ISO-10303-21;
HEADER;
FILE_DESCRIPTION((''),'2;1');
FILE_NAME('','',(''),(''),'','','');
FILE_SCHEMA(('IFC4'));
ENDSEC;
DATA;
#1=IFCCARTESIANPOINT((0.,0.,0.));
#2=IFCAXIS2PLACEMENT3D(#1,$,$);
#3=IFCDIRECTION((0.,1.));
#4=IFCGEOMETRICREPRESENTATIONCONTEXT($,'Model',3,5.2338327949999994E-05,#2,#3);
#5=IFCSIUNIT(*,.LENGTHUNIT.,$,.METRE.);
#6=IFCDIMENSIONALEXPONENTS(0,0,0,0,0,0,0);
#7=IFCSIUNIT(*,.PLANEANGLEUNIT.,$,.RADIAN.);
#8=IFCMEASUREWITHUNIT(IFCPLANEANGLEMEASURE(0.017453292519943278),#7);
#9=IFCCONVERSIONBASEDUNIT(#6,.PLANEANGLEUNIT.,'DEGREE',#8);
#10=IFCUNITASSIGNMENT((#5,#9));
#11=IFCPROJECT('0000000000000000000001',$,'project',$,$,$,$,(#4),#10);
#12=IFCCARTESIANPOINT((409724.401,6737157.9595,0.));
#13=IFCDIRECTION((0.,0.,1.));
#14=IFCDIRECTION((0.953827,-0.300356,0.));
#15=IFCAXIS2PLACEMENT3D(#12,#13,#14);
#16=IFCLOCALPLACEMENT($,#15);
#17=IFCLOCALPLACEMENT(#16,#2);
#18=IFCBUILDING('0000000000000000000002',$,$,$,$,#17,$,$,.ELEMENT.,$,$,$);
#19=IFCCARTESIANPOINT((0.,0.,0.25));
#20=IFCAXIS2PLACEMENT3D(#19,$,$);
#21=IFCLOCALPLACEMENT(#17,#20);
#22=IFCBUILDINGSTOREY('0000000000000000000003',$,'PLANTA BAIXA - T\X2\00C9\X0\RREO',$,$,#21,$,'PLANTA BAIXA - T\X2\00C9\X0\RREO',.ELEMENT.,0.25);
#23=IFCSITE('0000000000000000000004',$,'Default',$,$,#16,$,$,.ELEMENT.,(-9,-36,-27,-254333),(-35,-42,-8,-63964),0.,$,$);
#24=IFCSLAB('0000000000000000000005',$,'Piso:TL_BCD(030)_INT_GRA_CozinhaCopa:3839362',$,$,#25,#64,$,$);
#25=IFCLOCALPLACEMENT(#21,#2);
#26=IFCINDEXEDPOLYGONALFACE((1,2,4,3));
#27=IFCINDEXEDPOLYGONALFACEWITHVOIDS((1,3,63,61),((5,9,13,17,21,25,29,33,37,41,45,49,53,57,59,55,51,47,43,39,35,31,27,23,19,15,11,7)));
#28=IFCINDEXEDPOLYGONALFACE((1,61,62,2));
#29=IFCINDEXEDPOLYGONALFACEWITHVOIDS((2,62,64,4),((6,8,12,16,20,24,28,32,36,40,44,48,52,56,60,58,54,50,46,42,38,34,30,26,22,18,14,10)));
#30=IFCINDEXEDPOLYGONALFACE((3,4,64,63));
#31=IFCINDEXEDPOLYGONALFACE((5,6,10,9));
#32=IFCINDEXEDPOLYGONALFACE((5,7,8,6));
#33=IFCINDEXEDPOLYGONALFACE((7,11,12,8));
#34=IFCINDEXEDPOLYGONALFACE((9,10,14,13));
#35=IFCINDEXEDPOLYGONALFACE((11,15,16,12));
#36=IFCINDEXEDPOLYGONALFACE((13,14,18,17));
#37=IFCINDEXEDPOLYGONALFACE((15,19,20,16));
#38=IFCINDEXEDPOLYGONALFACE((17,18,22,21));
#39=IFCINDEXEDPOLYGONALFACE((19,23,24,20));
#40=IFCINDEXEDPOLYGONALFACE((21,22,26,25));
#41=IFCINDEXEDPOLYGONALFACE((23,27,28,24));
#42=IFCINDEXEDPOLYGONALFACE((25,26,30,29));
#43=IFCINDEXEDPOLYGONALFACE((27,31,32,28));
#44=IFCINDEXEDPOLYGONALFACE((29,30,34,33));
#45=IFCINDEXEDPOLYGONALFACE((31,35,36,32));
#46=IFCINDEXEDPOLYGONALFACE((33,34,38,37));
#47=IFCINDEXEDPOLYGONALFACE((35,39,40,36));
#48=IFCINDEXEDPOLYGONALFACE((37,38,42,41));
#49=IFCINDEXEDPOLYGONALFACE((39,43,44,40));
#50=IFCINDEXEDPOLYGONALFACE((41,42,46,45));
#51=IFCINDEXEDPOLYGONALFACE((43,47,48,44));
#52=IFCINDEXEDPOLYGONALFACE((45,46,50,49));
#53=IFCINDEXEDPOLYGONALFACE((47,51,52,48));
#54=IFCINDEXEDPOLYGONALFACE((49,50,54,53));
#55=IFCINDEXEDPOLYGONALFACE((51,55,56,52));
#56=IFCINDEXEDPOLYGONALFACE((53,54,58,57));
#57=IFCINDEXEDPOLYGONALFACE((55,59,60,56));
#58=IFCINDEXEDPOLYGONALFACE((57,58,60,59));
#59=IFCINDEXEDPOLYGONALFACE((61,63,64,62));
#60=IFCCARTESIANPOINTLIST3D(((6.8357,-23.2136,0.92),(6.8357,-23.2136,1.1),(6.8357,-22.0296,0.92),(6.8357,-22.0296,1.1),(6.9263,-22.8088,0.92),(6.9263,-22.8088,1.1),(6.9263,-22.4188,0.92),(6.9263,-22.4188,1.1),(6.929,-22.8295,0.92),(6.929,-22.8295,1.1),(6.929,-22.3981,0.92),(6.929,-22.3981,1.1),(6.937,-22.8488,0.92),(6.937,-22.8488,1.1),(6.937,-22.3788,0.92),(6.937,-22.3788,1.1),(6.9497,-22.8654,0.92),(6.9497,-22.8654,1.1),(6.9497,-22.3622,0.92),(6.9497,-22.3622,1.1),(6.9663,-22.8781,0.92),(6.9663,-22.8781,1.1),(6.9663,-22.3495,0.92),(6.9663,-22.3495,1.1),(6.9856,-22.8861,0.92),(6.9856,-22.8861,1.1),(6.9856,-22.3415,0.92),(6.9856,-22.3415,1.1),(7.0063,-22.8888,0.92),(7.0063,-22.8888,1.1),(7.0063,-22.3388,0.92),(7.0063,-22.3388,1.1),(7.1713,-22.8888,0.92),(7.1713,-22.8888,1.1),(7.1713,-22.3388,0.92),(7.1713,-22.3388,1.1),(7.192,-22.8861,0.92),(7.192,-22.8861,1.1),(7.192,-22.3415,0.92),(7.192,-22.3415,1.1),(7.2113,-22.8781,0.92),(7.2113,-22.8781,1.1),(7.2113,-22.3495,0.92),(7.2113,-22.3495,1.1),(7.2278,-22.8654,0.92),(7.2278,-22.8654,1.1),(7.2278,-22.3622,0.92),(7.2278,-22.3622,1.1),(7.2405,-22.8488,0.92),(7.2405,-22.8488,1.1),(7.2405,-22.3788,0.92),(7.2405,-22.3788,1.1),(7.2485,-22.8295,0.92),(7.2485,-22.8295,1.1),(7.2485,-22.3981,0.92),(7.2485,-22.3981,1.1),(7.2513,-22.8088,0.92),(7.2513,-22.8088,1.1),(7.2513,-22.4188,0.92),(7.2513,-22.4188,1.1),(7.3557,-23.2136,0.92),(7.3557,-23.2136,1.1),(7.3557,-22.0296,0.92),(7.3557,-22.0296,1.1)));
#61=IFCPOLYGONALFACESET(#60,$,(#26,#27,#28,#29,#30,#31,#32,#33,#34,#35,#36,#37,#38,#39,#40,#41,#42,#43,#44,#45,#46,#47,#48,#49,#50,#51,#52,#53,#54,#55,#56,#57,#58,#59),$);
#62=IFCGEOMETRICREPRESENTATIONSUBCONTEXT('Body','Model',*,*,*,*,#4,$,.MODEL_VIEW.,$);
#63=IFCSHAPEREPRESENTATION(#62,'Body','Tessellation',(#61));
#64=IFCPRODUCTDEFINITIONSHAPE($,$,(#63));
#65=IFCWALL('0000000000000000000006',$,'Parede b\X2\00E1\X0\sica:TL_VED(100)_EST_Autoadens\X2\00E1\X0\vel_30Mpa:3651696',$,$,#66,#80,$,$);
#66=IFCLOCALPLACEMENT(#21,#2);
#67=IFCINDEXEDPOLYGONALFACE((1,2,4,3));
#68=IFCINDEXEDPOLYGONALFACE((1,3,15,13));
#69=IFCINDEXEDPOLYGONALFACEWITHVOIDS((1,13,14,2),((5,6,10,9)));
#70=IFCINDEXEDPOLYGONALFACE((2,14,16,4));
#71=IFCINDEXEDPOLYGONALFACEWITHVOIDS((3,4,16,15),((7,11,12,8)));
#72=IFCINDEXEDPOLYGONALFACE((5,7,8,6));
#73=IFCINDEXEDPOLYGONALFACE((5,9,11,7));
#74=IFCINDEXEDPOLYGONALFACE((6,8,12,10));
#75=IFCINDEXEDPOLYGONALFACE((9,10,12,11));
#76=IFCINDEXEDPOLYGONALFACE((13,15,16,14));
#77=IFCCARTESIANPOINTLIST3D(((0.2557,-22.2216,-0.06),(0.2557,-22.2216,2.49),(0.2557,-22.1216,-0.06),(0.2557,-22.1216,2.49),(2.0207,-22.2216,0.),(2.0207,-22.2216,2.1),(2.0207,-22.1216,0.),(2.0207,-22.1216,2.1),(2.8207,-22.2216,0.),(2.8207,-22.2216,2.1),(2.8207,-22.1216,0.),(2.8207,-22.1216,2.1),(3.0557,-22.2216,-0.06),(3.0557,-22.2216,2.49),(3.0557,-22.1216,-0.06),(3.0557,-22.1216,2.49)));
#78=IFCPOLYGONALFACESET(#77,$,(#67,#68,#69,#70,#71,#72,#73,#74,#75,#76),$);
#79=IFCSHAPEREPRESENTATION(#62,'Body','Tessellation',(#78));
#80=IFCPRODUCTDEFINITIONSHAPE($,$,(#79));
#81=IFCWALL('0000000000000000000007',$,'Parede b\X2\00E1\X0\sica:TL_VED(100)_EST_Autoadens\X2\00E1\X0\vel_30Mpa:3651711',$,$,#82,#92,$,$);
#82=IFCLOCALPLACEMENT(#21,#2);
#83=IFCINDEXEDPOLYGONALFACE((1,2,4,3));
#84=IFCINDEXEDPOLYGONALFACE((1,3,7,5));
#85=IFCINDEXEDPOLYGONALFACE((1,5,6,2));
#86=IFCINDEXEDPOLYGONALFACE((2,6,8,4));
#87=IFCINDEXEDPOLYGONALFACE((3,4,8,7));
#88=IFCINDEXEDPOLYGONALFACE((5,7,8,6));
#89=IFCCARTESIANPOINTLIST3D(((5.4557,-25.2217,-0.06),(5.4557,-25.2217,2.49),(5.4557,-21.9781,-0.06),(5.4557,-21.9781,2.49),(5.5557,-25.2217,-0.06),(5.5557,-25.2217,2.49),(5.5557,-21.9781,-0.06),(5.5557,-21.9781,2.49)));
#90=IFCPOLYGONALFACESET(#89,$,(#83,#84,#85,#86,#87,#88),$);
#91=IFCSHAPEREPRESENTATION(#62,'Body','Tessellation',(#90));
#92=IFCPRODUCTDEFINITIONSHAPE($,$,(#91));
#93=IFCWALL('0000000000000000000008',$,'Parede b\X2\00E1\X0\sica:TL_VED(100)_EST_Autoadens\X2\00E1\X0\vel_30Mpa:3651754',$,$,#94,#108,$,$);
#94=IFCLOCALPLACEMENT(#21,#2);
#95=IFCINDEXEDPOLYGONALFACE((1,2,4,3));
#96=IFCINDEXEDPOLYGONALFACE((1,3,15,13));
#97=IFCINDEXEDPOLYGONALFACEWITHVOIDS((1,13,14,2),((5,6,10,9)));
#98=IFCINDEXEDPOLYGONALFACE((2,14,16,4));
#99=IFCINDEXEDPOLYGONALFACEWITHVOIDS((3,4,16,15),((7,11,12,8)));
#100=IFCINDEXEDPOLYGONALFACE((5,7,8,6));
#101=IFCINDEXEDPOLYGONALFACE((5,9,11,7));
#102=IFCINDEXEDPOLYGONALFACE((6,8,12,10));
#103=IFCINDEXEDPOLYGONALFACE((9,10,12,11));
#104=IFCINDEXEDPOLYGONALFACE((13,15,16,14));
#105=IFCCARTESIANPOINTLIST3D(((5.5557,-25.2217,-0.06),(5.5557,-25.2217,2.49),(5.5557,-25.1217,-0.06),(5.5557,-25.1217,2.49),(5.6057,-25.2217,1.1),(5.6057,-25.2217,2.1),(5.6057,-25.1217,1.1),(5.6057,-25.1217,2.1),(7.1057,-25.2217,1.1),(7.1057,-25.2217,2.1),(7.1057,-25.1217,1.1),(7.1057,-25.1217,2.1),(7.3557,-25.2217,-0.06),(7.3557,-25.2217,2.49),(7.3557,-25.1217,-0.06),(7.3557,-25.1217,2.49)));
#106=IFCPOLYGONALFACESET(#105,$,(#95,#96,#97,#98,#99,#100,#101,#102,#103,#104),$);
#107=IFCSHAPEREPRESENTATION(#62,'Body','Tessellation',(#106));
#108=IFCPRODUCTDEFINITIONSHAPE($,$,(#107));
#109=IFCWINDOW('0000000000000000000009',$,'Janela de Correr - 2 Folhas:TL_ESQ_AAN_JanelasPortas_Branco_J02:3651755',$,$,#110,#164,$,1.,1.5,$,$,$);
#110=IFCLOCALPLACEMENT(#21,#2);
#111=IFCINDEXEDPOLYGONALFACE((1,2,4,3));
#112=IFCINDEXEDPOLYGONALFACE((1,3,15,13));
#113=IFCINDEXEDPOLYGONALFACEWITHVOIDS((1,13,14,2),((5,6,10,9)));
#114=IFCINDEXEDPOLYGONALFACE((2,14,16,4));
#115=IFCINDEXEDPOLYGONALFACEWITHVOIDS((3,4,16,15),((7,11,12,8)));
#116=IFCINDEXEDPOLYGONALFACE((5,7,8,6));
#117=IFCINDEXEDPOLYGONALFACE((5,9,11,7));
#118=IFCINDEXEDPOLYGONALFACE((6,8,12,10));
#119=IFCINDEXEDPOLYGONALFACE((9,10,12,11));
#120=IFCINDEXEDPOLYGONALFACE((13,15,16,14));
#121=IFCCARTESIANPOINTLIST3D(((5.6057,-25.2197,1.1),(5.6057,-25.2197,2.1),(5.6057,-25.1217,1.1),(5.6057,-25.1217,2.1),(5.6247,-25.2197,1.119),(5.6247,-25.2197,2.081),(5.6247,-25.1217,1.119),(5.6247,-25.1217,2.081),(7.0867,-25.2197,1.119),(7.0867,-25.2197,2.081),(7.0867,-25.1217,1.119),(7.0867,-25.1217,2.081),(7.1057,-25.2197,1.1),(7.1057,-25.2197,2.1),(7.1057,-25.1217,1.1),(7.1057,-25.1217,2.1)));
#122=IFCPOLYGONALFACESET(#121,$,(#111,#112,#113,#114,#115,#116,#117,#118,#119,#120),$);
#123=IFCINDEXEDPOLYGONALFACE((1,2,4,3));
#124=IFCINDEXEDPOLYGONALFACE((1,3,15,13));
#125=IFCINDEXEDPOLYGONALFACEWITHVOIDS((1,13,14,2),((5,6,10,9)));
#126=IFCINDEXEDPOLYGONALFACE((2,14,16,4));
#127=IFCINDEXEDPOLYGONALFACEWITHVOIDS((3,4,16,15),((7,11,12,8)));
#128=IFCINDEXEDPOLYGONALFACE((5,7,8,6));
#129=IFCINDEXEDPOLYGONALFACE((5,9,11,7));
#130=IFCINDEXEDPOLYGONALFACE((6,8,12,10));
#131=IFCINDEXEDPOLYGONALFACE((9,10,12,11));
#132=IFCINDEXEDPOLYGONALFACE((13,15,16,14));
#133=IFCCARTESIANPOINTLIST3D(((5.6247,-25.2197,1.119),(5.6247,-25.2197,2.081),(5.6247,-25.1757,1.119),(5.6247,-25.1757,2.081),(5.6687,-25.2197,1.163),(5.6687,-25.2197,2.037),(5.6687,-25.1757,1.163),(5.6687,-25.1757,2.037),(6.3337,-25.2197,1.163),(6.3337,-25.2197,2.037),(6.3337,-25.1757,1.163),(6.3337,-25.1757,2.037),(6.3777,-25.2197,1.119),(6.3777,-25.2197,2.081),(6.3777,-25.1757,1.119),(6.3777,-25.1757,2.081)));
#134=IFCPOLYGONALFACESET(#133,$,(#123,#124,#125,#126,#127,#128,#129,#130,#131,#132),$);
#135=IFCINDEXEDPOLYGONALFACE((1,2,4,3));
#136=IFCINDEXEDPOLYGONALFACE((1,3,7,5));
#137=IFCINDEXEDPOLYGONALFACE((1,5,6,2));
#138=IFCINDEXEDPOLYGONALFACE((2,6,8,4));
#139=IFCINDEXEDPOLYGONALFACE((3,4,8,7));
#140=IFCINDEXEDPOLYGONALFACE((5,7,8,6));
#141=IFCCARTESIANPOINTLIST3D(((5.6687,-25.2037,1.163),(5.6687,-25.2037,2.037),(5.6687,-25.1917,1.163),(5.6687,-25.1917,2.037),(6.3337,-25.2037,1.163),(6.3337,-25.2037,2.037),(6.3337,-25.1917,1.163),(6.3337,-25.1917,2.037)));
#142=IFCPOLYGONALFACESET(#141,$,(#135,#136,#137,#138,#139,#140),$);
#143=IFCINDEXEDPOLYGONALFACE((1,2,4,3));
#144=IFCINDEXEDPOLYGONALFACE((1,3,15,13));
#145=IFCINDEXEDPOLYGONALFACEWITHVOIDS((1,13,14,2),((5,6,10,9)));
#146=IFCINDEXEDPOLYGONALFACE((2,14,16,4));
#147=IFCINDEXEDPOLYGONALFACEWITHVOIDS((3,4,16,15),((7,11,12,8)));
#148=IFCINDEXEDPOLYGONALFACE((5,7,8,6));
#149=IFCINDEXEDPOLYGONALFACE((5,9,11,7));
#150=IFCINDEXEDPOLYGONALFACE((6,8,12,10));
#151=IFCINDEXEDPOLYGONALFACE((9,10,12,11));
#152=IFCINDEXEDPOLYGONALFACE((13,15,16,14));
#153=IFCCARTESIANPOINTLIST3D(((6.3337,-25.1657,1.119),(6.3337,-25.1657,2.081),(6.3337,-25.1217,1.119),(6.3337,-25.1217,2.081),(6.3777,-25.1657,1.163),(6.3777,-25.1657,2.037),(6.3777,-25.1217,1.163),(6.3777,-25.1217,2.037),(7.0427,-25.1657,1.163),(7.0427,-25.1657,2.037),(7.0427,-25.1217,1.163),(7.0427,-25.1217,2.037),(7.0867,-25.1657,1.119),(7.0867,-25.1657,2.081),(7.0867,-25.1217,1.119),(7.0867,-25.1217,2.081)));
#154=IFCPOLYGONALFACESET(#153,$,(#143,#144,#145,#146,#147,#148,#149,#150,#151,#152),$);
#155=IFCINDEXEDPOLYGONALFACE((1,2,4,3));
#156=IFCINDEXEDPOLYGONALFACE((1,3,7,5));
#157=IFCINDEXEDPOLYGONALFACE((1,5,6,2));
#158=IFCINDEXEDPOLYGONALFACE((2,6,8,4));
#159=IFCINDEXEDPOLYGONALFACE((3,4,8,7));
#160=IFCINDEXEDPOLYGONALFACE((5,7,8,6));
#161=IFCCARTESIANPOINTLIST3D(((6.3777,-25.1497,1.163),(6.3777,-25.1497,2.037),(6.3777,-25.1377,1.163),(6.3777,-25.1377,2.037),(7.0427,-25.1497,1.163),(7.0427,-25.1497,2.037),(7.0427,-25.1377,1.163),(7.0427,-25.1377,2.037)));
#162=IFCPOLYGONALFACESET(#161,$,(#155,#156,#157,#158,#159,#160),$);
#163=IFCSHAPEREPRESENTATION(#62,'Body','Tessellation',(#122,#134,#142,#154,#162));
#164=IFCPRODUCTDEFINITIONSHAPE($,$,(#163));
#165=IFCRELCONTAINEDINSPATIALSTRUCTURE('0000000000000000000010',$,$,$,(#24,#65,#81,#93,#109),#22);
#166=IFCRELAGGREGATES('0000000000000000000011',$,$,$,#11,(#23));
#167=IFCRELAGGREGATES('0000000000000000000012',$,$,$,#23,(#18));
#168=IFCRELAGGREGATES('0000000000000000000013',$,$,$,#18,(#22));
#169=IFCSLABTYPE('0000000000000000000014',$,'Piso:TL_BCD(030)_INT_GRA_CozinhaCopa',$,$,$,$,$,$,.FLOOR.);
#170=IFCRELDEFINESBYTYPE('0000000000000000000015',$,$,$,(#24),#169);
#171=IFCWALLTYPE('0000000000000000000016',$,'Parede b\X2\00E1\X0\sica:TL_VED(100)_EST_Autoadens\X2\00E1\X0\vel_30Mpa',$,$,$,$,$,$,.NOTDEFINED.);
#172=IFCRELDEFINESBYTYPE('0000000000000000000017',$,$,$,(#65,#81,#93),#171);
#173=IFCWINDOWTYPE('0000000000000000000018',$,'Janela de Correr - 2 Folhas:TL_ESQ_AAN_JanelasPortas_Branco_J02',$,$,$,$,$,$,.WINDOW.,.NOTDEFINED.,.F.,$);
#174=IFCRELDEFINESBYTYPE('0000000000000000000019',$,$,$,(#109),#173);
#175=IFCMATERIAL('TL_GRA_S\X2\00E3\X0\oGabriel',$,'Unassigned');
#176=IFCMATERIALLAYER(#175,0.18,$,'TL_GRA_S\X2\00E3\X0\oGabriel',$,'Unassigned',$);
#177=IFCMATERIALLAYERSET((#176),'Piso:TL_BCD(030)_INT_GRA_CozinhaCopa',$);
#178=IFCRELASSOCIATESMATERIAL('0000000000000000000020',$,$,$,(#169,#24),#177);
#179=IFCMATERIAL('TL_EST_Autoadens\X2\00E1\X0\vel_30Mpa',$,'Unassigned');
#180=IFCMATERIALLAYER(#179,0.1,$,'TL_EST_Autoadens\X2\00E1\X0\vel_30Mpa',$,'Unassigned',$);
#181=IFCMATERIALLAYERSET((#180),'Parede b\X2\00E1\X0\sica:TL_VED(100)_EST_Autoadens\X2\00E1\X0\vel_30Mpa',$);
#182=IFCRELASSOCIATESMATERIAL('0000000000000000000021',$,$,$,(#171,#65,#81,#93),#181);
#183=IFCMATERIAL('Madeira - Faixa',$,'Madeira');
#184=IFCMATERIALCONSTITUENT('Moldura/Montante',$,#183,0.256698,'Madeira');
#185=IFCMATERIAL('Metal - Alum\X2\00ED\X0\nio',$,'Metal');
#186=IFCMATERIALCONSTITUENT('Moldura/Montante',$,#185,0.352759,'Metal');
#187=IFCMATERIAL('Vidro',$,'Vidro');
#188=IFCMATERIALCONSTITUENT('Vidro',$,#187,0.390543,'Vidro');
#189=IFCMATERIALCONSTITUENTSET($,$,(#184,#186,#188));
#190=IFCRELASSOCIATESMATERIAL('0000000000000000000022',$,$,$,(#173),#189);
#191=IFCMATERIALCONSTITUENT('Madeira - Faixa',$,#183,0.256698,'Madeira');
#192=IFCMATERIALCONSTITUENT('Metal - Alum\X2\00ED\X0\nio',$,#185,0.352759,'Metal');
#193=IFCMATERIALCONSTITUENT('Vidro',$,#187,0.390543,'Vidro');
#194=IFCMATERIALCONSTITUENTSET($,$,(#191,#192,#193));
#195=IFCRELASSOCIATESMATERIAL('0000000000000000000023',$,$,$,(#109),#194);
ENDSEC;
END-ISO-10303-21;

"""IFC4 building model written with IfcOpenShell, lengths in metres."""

from ifc_helpers import new_model, entity, si_unit, converted_unit, direction, frame, frame_2d, origin, origin_2d_with_axis, place, context, subcontext, project, spatial, polyline, circle_curve, parameter, trimmed, segment, composite_curve, rectangle, outline, extrude, source, transform, mapped, material, layer, layer_set, layer_usage, constituent, constituent_set, type_object, type_shapes, element, fill, save


model = new_model("IFC4")

# Units and contexts
model_context = context("Model", 3, precision=5.2338327949999994e-05, world=origin(), true_north=direction((0.0, 1.0)))
body_context = subcontext(model_context, "Body", "Model", "MODEL_VIEW")
ifc_project = project(units=[si_unit("LENGTHUNIT", "METRE"), converted_unit("PLANEANGLEUNIT", "DEGREE", entity("IfcPlaneAngleMeasure", 0.017453292519943278), si_unit("PLANEANGLEUNIT", "RADIAN"), dimensions=[0, 0, 0, 0, 0, 0, 0])], contexts=[model_context])

# Site, building, storey
site_placement = place(None, frame((409724.401, 6737157.9595, 0.0), z_axis=(0.0, 0.0, 1.0), x_axis=(0.953827, -0.300356, 0.0)))
site = spatial("IfcSite", under=ifc_project, at=site_placement, Name="Default", CompositionType="ELEMENT", RefLatitude=(-9, -36, -27, -254333), RefLongitude=(-35, -42, -8, -63964), RefElevation=0.0)
building_placement = place(site_placement, origin())
building = spatial("IfcBuilding", under=site, at=building_placement, CompositionType="ELEMENT")
storey_placement = place(building_placement, frame((0.0, 0.0, 0.25)))
storey = spatial("IfcBuildingStorey", under=building, at=storey_placement, Name="PLANTA BAIXA - TÉRREO", LongName="PLANTA BAIXA - TÉRREO", CompositionType="ELEMENT", Elevation=0.25)

# Slab, opening
ifc_material_1 = material(Name="TL_GRA_SãoGabriel", Category="Unassigned")
ifc_layer_1 = layer(ifc_material_1, 0.18, Name="TL_GRA_SãoGabriel", Category="Unassigned")
ifc_layer_set_1 = layer_set([ifc_layer_1], Name="Piso:TL_BCD(030)_INT_GRA_CozinhaCopa")
ifc_layer_usage_1 = layer_usage(ifc_layer_set_1, "AXIS3", "POSITIVE", 0.0)
slab_type = type_object("IfcSlabType", Name="Piso:TL_BCD(030)_INT_GRA_CozinhaCopa", PredefinedType="FLOOR", material=ifc_layer_set_1)
slab_placement = place(storey_placement, frame((6.8357, -23.2136, 0.92)))
slab = element("IfcSlab", 1, at=slab_placement, inside=storey, type_object=slab_type, material=ifc_layer_usage_1, Name="Piso:TL_BCD(030)_INT_GRA_CozinhaCopa:3839362", context=body_context, shape_type="SweptSolid", body=[
    extrude(rectangle(XDim=0.52, YDim=1.184, at=origin_2d_with_axis()), frame((0.26, 0.592, 0.18), z_axis=(0.0, 0.0, -1.0), x_axis=(-1.0, 0.0, 0.0)), (0.0, 0.0, 1.0), 0.18),
])
opening_1_placement = place(slab_placement, frame((-6.8357, 23.2136, 0.18)))
element("IfcOpeningElement", 2, at=opening_1_placement, cuts=slab, PredefinedType="OPENING", context=body_context, shape_type="SweptSolid", body=[
    extrude(outline(composite_curve([segment(trimmed(circle_curve(frame_2d((0.195, -0.0825), x_axis=(1.0, 0.0)), 0.08), [parameter(270.0)], [parameter(0.0)], True, "PARAMETER"), True, "CONTINUOUS"), segment(polyline([(0.275, -0.0825), (0.275, 0.0825)]), True, "CONTINUOUS"), segment(trimmed(circle_curve(frame_2d((0.195, 0.0825), x_axis=(1.0, 0.0)), 0.08), [parameter(0.0)], [parameter(90.0)], True, "PARAMETER"), True, "CONTINUOUS"), segment(polyline([(0.195, 0.1625), (-0.195, 0.1625)]), True, "CONTINUOUS"), segment(trimmed(circle_curve(frame_2d((-0.195, 0.0825), x_axis=(1.0, 0.0)), 0.08), [parameter(90.0)], [parameter(180.0)], True, "PARAMETER"), True, "CONTINUOUS"), segment(polyline([(-0.275, 0.0825), (-0.275, -0.0825)]), True, "CONTINUOUS"), segment(trimmed(circle_curve(frame_2d((-0.195, -0.0825), x_axis=(1.0, 0.0)), 0.08), [parameter(180.0)], [parameter(270.0)], True, "PARAMETER"), True, "CONTINUOUS"), segment(polyline([(-0.195, -0.1625), (0.195, -0.1625)]), True, "CONTINUOUS")], self_intersect=False)), frame((7.0888, -22.6138, -0.21), z_axis=(0.0, 0.0, 1.0), x_axis=(0.0, 1.0, 0.0)), (0.0, 0.0, 1.0), 0.21),
])

# Wall, opening
ifc_material_2 = material(Name="TL_EST_Autoadensável_30Mpa", Category="Unassigned")
ifc_layer_2 = layer(ifc_material_2, 0.1, Name="TL_EST_Autoadensável_30Mpa", Category="Unassigned")
ifc_layer_set_2 = layer_set([ifc_layer_2], Name="Parede básica:TL_VED(100)_EST_Autoadensável_30Mpa")
ifc_layer_usage_2 = layer_usage(ifc_layer_set_2, "AXIS2", "NEGATIVE", 0.05)
wall_type_1 = type_object("IfcWallType", Name="Parede básica:TL_VED(100)_EST_Autoadensável_30Mpa", PredefinedType="NOTDEFINED", material=ifc_layer_set_2)
wall_1_placement = place(storey_placement, frame((3.0557, -22.1716, -0.06), z_axis=(0.0, 0.0, 1.0), x_axis=(-1.0, 0.0, 0.0)))
wall_1 = element("IfcWall", 3, at=wall_1_placement, inside=storey, type_object=wall_type_1, material=ifc_layer_usage_2, Name="Parede básica:TL_VED(100)_EST_Autoadensável_30Mpa:3651696", context=body_context, shape_type="SweptSolid", body=[
    extrude(rectangle(XDim=2.8, YDim=0.1, at=frame_2d((1.4, 0.0), x_axis=(-1.0, 0.0))), origin(), (0.0, 0.0, 1.0), 2.55),
])
opening_2_placement = place(wall_1_placement, frame((0.235, -0.05, 0.06)))
element("IfcOpeningElement", 4, at=opening_2_placement, cuts=wall_1, PredefinedType="OPENING", context=body_context, shape_type="SweptSolid", body=[
    extrude(rectangle(XDim=2.1, YDim=0.8, at=frame_2d((1.05, 0.4), x_axis=(1.0, 0.0))), frame((0.0, 0.0, 0.0), z_axis=(0.0, 1.0, 0.0), x_axis=(0.0, 0.0, 1.0)), (0.0, 0.0, 1.0), 0.1),
])

# Wall
ifc_layer_usage_3 = layer_usage(ifc_layer_set_2, "AXIS2", "POSITIVE", -0.05)
wall_2_placement = place(storey_placement, frame((5.5057, -25.2217, -0.06), z_axis=(0.0, 0.0, 1.0), x_axis=(0.0, 1.0, 0.0)))
element("IfcWall", 5, at=wall_2_placement, inside=storey, type_object=wall_type_1, material=ifc_layer_usage_3, Name="Parede básica:TL_VED(100)_EST_Autoadensável_30Mpa:3651711", context=body_context, shape_type="SweptSolid", body=[
    extrude(rectangle(XDim=3.2437, YDim=0.1, at=frame_2d((1.6218, 0.0), x_axis=(-1.0, 0.0))), origin(), (0.0, 0.0, 1.0), 2.55),
])

# Wall, opening, window
ifc_layer_usage_4 = layer_usage(ifc_layer_set_2, "AXIS2", "POSITIVE", -0.05)
wall_3_placement = place(storey_placement, frame((5.5557, -25.1717, -0.06)))
wall_3 = element("IfcWall", 6, at=wall_3_placement, inside=storey, type_object=wall_type_1, material=ifc_layer_usage_4, Name="Parede básica:TL_VED(100)_EST_Autoadensável_30Mpa:3651754", context=body_context, shape_type="SweptSolid", body=[
    extrude(rectangle(XDim=1.8, YDim=0.1, at=frame_2d((0.9, 0.0), x_axis=(-1.0, 0.0))), origin(), (0.0, 0.0, 1.0), 2.55),
])
opening_3_placement = place(wall_3_placement, frame((1.55, 0.05, 1.16)))
opening_3 = element("IfcOpeningElement", 7, at=opening_3_placement, cuts=wall_3, PredefinedType="OPENING", context=body_context, shape_type="SweptSolid", body=[
    extrude(rectangle(XDim=1.0, YDim=1.5, at=frame_2d((0.5, 0.75), x_axis=(-1.0, 0.0))), frame((0.0, 0.0, 0.0), z_axis=(0.0, -1.0, 0.0), x_axis=(0.0, 0.0, 1.0)), (0.0, 0.0, 1.0), 0.1),
])
ifc_material_3 = material(Name="Madeira - Faixa", Category="Madeira")
ifc_constituent_1 = constituent(ifc_material_3, Name="Madeira - Faixa", Category="Madeira", fraction=0.256698)
ifc_material_4 = material(Name="Metal - Alumínio", Category="Metal")
ifc_constituent_2 = constituent(ifc_material_4, Name="Metal - Alumínio", Category="Metal", fraction=0.352759)
ifc_material_5 = material(Name="Vidro", Category="Vidro")
ifc_constituent_3 = constituent(ifc_material_5, Name="Vidro", Category="Vidro", fraction=0.390543)
ifc_constituent_set_1 = constituent_set(constituents=[ifc_constituent_1, ifc_constituent_2, ifc_constituent_3])
ifc_constituent_4 = constituent(ifc_material_3, Name="Moldura/Montante", Category="Madeira", fraction=0.256698)
ifc_constituent_5 = constituent(ifc_material_4, Name="Moldura/Montante", Category="Metal", fraction=0.352759)
ifc_constituent_6 = constituent(ifc_material_5, Name="Vidro", Category="Vidro", fraction=0.390543)
ifc_constituent_set_2 = constituent_set(constituents=[ifc_constituent_4, ifc_constituent_5, ifc_constituent_6])
window_type = type_object("IfcWindowType", Name="Janela de Correr - 2 Folhas:TL_ESQ_AAN_JanelasPortas_Branco_J02", ParameterTakesPrecedence=False, PartitioningType="NOTDEFINED", PredefinedType="WINDOW", material=ifc_constituent_set_2)
shared_shape_1 = source(origin(), body_context, "Body", "SweptSolid", [
    extrude(outline(polyline([(-0.75, -0.5), (0.75, -0.5), (0.75, 0.5), (-0.75, 0.5), (-0.75, -0.5)]), holes=[polyline([(-0.731, -0.481), (-0.731, 0.481), (0.731, 0.481), (0.731, -0.481), (-0.731, -0.481)])]), frame((0.75, 0.0, 0.5), z_axis=(0.0, 1.0, 0.0), x_axis=(1.0, 0.0, 0.0)), (0.0, 0.0, 1.0), 0.098),
    extrude(outline(polyline([(-0.3765, -0.481), (0.3765, -0.481), (0.3765, 0.481), (-0.3765, 0.481), (-0.3765, -0.481)]), holes=[polyline([(-0.3325, -0.437), (-0.3325, 0.437), (0.3325, 0.437), (0.3325, -0.437), (-0.3325, -0.437)])]), frame((1.1045, 0.054, 0.5), z_axis=(0.0, 1.0, 0.0), x_axis=(1.0, 0.0, 0.0)), (0.0, 0.0, 1.0), 0.044),
    extrude(rectangle(XDim=0.012, YDim=0.665, at=origin_2d_with_axis()), frame((1.1045, 0.076, 0.063), z_axis=(0.0, 0.0, 1.0), x_axis=(0.0, -1.0, 0.0)), (0.0, 0.0, 1.0), 0.874),
    extrude(outline(polyline([(-0.481, -0.3765), (0.481, -0.3765), (0.481, 0.3765), (-0.481, 0.3765), (-0.481, -0.3765)]), holes=[polyline([(-0.437, -0.3325), (-0.437, 0.3325), (0.437, 0.3325), (0.437, -0.3325), (-0.437, -0.3325)])]), frame((0.3955, 0.0, 0.5), z_axis=(0.0, 1.0, 0.0), x_axis=(0.0, 0.0, -1.0)), (0.0, 0.0, 1.0), 0.044),
    extrude(rectangle(XDim=0.012, YDim=0.665, at=origin_2d_with_axis()), frame((0.3955, 0.022, 0.063), z_axis=(0.0, 0.0, 1.0), x_axis=(0.0, -1.0, 0.0)), (0.0, 0.0, 1.0), 0.874),
])
type_shapes(window_type, [shared_shape_1])
window_placement = place(opening_3_placement, frame((0.0, 0.0, 0.0), z_axis=(0.0, 0.0, 1.0), x_axis=(-1.0, 0.0, 0.0)))
window = element("IfcWindow", 8, at=window_placement, inside=storey, type_object=window_type, material=ifc_constituent_set_1, Name="Janela de Correr - 2 Folhas:TL_ESQ_AAN_JanelasPortas_Branco_J02:3651755", OverallHeight=1.0, OverallWidth=1.5, context=body_context, shape_type="MappedRepresentation", body=[
    mapped(shared_shape_1, transform((0.0, 0.0, 0.0), scale=1.0)),
])
fill(opening_3, window)

save(model, "model.ifc")
